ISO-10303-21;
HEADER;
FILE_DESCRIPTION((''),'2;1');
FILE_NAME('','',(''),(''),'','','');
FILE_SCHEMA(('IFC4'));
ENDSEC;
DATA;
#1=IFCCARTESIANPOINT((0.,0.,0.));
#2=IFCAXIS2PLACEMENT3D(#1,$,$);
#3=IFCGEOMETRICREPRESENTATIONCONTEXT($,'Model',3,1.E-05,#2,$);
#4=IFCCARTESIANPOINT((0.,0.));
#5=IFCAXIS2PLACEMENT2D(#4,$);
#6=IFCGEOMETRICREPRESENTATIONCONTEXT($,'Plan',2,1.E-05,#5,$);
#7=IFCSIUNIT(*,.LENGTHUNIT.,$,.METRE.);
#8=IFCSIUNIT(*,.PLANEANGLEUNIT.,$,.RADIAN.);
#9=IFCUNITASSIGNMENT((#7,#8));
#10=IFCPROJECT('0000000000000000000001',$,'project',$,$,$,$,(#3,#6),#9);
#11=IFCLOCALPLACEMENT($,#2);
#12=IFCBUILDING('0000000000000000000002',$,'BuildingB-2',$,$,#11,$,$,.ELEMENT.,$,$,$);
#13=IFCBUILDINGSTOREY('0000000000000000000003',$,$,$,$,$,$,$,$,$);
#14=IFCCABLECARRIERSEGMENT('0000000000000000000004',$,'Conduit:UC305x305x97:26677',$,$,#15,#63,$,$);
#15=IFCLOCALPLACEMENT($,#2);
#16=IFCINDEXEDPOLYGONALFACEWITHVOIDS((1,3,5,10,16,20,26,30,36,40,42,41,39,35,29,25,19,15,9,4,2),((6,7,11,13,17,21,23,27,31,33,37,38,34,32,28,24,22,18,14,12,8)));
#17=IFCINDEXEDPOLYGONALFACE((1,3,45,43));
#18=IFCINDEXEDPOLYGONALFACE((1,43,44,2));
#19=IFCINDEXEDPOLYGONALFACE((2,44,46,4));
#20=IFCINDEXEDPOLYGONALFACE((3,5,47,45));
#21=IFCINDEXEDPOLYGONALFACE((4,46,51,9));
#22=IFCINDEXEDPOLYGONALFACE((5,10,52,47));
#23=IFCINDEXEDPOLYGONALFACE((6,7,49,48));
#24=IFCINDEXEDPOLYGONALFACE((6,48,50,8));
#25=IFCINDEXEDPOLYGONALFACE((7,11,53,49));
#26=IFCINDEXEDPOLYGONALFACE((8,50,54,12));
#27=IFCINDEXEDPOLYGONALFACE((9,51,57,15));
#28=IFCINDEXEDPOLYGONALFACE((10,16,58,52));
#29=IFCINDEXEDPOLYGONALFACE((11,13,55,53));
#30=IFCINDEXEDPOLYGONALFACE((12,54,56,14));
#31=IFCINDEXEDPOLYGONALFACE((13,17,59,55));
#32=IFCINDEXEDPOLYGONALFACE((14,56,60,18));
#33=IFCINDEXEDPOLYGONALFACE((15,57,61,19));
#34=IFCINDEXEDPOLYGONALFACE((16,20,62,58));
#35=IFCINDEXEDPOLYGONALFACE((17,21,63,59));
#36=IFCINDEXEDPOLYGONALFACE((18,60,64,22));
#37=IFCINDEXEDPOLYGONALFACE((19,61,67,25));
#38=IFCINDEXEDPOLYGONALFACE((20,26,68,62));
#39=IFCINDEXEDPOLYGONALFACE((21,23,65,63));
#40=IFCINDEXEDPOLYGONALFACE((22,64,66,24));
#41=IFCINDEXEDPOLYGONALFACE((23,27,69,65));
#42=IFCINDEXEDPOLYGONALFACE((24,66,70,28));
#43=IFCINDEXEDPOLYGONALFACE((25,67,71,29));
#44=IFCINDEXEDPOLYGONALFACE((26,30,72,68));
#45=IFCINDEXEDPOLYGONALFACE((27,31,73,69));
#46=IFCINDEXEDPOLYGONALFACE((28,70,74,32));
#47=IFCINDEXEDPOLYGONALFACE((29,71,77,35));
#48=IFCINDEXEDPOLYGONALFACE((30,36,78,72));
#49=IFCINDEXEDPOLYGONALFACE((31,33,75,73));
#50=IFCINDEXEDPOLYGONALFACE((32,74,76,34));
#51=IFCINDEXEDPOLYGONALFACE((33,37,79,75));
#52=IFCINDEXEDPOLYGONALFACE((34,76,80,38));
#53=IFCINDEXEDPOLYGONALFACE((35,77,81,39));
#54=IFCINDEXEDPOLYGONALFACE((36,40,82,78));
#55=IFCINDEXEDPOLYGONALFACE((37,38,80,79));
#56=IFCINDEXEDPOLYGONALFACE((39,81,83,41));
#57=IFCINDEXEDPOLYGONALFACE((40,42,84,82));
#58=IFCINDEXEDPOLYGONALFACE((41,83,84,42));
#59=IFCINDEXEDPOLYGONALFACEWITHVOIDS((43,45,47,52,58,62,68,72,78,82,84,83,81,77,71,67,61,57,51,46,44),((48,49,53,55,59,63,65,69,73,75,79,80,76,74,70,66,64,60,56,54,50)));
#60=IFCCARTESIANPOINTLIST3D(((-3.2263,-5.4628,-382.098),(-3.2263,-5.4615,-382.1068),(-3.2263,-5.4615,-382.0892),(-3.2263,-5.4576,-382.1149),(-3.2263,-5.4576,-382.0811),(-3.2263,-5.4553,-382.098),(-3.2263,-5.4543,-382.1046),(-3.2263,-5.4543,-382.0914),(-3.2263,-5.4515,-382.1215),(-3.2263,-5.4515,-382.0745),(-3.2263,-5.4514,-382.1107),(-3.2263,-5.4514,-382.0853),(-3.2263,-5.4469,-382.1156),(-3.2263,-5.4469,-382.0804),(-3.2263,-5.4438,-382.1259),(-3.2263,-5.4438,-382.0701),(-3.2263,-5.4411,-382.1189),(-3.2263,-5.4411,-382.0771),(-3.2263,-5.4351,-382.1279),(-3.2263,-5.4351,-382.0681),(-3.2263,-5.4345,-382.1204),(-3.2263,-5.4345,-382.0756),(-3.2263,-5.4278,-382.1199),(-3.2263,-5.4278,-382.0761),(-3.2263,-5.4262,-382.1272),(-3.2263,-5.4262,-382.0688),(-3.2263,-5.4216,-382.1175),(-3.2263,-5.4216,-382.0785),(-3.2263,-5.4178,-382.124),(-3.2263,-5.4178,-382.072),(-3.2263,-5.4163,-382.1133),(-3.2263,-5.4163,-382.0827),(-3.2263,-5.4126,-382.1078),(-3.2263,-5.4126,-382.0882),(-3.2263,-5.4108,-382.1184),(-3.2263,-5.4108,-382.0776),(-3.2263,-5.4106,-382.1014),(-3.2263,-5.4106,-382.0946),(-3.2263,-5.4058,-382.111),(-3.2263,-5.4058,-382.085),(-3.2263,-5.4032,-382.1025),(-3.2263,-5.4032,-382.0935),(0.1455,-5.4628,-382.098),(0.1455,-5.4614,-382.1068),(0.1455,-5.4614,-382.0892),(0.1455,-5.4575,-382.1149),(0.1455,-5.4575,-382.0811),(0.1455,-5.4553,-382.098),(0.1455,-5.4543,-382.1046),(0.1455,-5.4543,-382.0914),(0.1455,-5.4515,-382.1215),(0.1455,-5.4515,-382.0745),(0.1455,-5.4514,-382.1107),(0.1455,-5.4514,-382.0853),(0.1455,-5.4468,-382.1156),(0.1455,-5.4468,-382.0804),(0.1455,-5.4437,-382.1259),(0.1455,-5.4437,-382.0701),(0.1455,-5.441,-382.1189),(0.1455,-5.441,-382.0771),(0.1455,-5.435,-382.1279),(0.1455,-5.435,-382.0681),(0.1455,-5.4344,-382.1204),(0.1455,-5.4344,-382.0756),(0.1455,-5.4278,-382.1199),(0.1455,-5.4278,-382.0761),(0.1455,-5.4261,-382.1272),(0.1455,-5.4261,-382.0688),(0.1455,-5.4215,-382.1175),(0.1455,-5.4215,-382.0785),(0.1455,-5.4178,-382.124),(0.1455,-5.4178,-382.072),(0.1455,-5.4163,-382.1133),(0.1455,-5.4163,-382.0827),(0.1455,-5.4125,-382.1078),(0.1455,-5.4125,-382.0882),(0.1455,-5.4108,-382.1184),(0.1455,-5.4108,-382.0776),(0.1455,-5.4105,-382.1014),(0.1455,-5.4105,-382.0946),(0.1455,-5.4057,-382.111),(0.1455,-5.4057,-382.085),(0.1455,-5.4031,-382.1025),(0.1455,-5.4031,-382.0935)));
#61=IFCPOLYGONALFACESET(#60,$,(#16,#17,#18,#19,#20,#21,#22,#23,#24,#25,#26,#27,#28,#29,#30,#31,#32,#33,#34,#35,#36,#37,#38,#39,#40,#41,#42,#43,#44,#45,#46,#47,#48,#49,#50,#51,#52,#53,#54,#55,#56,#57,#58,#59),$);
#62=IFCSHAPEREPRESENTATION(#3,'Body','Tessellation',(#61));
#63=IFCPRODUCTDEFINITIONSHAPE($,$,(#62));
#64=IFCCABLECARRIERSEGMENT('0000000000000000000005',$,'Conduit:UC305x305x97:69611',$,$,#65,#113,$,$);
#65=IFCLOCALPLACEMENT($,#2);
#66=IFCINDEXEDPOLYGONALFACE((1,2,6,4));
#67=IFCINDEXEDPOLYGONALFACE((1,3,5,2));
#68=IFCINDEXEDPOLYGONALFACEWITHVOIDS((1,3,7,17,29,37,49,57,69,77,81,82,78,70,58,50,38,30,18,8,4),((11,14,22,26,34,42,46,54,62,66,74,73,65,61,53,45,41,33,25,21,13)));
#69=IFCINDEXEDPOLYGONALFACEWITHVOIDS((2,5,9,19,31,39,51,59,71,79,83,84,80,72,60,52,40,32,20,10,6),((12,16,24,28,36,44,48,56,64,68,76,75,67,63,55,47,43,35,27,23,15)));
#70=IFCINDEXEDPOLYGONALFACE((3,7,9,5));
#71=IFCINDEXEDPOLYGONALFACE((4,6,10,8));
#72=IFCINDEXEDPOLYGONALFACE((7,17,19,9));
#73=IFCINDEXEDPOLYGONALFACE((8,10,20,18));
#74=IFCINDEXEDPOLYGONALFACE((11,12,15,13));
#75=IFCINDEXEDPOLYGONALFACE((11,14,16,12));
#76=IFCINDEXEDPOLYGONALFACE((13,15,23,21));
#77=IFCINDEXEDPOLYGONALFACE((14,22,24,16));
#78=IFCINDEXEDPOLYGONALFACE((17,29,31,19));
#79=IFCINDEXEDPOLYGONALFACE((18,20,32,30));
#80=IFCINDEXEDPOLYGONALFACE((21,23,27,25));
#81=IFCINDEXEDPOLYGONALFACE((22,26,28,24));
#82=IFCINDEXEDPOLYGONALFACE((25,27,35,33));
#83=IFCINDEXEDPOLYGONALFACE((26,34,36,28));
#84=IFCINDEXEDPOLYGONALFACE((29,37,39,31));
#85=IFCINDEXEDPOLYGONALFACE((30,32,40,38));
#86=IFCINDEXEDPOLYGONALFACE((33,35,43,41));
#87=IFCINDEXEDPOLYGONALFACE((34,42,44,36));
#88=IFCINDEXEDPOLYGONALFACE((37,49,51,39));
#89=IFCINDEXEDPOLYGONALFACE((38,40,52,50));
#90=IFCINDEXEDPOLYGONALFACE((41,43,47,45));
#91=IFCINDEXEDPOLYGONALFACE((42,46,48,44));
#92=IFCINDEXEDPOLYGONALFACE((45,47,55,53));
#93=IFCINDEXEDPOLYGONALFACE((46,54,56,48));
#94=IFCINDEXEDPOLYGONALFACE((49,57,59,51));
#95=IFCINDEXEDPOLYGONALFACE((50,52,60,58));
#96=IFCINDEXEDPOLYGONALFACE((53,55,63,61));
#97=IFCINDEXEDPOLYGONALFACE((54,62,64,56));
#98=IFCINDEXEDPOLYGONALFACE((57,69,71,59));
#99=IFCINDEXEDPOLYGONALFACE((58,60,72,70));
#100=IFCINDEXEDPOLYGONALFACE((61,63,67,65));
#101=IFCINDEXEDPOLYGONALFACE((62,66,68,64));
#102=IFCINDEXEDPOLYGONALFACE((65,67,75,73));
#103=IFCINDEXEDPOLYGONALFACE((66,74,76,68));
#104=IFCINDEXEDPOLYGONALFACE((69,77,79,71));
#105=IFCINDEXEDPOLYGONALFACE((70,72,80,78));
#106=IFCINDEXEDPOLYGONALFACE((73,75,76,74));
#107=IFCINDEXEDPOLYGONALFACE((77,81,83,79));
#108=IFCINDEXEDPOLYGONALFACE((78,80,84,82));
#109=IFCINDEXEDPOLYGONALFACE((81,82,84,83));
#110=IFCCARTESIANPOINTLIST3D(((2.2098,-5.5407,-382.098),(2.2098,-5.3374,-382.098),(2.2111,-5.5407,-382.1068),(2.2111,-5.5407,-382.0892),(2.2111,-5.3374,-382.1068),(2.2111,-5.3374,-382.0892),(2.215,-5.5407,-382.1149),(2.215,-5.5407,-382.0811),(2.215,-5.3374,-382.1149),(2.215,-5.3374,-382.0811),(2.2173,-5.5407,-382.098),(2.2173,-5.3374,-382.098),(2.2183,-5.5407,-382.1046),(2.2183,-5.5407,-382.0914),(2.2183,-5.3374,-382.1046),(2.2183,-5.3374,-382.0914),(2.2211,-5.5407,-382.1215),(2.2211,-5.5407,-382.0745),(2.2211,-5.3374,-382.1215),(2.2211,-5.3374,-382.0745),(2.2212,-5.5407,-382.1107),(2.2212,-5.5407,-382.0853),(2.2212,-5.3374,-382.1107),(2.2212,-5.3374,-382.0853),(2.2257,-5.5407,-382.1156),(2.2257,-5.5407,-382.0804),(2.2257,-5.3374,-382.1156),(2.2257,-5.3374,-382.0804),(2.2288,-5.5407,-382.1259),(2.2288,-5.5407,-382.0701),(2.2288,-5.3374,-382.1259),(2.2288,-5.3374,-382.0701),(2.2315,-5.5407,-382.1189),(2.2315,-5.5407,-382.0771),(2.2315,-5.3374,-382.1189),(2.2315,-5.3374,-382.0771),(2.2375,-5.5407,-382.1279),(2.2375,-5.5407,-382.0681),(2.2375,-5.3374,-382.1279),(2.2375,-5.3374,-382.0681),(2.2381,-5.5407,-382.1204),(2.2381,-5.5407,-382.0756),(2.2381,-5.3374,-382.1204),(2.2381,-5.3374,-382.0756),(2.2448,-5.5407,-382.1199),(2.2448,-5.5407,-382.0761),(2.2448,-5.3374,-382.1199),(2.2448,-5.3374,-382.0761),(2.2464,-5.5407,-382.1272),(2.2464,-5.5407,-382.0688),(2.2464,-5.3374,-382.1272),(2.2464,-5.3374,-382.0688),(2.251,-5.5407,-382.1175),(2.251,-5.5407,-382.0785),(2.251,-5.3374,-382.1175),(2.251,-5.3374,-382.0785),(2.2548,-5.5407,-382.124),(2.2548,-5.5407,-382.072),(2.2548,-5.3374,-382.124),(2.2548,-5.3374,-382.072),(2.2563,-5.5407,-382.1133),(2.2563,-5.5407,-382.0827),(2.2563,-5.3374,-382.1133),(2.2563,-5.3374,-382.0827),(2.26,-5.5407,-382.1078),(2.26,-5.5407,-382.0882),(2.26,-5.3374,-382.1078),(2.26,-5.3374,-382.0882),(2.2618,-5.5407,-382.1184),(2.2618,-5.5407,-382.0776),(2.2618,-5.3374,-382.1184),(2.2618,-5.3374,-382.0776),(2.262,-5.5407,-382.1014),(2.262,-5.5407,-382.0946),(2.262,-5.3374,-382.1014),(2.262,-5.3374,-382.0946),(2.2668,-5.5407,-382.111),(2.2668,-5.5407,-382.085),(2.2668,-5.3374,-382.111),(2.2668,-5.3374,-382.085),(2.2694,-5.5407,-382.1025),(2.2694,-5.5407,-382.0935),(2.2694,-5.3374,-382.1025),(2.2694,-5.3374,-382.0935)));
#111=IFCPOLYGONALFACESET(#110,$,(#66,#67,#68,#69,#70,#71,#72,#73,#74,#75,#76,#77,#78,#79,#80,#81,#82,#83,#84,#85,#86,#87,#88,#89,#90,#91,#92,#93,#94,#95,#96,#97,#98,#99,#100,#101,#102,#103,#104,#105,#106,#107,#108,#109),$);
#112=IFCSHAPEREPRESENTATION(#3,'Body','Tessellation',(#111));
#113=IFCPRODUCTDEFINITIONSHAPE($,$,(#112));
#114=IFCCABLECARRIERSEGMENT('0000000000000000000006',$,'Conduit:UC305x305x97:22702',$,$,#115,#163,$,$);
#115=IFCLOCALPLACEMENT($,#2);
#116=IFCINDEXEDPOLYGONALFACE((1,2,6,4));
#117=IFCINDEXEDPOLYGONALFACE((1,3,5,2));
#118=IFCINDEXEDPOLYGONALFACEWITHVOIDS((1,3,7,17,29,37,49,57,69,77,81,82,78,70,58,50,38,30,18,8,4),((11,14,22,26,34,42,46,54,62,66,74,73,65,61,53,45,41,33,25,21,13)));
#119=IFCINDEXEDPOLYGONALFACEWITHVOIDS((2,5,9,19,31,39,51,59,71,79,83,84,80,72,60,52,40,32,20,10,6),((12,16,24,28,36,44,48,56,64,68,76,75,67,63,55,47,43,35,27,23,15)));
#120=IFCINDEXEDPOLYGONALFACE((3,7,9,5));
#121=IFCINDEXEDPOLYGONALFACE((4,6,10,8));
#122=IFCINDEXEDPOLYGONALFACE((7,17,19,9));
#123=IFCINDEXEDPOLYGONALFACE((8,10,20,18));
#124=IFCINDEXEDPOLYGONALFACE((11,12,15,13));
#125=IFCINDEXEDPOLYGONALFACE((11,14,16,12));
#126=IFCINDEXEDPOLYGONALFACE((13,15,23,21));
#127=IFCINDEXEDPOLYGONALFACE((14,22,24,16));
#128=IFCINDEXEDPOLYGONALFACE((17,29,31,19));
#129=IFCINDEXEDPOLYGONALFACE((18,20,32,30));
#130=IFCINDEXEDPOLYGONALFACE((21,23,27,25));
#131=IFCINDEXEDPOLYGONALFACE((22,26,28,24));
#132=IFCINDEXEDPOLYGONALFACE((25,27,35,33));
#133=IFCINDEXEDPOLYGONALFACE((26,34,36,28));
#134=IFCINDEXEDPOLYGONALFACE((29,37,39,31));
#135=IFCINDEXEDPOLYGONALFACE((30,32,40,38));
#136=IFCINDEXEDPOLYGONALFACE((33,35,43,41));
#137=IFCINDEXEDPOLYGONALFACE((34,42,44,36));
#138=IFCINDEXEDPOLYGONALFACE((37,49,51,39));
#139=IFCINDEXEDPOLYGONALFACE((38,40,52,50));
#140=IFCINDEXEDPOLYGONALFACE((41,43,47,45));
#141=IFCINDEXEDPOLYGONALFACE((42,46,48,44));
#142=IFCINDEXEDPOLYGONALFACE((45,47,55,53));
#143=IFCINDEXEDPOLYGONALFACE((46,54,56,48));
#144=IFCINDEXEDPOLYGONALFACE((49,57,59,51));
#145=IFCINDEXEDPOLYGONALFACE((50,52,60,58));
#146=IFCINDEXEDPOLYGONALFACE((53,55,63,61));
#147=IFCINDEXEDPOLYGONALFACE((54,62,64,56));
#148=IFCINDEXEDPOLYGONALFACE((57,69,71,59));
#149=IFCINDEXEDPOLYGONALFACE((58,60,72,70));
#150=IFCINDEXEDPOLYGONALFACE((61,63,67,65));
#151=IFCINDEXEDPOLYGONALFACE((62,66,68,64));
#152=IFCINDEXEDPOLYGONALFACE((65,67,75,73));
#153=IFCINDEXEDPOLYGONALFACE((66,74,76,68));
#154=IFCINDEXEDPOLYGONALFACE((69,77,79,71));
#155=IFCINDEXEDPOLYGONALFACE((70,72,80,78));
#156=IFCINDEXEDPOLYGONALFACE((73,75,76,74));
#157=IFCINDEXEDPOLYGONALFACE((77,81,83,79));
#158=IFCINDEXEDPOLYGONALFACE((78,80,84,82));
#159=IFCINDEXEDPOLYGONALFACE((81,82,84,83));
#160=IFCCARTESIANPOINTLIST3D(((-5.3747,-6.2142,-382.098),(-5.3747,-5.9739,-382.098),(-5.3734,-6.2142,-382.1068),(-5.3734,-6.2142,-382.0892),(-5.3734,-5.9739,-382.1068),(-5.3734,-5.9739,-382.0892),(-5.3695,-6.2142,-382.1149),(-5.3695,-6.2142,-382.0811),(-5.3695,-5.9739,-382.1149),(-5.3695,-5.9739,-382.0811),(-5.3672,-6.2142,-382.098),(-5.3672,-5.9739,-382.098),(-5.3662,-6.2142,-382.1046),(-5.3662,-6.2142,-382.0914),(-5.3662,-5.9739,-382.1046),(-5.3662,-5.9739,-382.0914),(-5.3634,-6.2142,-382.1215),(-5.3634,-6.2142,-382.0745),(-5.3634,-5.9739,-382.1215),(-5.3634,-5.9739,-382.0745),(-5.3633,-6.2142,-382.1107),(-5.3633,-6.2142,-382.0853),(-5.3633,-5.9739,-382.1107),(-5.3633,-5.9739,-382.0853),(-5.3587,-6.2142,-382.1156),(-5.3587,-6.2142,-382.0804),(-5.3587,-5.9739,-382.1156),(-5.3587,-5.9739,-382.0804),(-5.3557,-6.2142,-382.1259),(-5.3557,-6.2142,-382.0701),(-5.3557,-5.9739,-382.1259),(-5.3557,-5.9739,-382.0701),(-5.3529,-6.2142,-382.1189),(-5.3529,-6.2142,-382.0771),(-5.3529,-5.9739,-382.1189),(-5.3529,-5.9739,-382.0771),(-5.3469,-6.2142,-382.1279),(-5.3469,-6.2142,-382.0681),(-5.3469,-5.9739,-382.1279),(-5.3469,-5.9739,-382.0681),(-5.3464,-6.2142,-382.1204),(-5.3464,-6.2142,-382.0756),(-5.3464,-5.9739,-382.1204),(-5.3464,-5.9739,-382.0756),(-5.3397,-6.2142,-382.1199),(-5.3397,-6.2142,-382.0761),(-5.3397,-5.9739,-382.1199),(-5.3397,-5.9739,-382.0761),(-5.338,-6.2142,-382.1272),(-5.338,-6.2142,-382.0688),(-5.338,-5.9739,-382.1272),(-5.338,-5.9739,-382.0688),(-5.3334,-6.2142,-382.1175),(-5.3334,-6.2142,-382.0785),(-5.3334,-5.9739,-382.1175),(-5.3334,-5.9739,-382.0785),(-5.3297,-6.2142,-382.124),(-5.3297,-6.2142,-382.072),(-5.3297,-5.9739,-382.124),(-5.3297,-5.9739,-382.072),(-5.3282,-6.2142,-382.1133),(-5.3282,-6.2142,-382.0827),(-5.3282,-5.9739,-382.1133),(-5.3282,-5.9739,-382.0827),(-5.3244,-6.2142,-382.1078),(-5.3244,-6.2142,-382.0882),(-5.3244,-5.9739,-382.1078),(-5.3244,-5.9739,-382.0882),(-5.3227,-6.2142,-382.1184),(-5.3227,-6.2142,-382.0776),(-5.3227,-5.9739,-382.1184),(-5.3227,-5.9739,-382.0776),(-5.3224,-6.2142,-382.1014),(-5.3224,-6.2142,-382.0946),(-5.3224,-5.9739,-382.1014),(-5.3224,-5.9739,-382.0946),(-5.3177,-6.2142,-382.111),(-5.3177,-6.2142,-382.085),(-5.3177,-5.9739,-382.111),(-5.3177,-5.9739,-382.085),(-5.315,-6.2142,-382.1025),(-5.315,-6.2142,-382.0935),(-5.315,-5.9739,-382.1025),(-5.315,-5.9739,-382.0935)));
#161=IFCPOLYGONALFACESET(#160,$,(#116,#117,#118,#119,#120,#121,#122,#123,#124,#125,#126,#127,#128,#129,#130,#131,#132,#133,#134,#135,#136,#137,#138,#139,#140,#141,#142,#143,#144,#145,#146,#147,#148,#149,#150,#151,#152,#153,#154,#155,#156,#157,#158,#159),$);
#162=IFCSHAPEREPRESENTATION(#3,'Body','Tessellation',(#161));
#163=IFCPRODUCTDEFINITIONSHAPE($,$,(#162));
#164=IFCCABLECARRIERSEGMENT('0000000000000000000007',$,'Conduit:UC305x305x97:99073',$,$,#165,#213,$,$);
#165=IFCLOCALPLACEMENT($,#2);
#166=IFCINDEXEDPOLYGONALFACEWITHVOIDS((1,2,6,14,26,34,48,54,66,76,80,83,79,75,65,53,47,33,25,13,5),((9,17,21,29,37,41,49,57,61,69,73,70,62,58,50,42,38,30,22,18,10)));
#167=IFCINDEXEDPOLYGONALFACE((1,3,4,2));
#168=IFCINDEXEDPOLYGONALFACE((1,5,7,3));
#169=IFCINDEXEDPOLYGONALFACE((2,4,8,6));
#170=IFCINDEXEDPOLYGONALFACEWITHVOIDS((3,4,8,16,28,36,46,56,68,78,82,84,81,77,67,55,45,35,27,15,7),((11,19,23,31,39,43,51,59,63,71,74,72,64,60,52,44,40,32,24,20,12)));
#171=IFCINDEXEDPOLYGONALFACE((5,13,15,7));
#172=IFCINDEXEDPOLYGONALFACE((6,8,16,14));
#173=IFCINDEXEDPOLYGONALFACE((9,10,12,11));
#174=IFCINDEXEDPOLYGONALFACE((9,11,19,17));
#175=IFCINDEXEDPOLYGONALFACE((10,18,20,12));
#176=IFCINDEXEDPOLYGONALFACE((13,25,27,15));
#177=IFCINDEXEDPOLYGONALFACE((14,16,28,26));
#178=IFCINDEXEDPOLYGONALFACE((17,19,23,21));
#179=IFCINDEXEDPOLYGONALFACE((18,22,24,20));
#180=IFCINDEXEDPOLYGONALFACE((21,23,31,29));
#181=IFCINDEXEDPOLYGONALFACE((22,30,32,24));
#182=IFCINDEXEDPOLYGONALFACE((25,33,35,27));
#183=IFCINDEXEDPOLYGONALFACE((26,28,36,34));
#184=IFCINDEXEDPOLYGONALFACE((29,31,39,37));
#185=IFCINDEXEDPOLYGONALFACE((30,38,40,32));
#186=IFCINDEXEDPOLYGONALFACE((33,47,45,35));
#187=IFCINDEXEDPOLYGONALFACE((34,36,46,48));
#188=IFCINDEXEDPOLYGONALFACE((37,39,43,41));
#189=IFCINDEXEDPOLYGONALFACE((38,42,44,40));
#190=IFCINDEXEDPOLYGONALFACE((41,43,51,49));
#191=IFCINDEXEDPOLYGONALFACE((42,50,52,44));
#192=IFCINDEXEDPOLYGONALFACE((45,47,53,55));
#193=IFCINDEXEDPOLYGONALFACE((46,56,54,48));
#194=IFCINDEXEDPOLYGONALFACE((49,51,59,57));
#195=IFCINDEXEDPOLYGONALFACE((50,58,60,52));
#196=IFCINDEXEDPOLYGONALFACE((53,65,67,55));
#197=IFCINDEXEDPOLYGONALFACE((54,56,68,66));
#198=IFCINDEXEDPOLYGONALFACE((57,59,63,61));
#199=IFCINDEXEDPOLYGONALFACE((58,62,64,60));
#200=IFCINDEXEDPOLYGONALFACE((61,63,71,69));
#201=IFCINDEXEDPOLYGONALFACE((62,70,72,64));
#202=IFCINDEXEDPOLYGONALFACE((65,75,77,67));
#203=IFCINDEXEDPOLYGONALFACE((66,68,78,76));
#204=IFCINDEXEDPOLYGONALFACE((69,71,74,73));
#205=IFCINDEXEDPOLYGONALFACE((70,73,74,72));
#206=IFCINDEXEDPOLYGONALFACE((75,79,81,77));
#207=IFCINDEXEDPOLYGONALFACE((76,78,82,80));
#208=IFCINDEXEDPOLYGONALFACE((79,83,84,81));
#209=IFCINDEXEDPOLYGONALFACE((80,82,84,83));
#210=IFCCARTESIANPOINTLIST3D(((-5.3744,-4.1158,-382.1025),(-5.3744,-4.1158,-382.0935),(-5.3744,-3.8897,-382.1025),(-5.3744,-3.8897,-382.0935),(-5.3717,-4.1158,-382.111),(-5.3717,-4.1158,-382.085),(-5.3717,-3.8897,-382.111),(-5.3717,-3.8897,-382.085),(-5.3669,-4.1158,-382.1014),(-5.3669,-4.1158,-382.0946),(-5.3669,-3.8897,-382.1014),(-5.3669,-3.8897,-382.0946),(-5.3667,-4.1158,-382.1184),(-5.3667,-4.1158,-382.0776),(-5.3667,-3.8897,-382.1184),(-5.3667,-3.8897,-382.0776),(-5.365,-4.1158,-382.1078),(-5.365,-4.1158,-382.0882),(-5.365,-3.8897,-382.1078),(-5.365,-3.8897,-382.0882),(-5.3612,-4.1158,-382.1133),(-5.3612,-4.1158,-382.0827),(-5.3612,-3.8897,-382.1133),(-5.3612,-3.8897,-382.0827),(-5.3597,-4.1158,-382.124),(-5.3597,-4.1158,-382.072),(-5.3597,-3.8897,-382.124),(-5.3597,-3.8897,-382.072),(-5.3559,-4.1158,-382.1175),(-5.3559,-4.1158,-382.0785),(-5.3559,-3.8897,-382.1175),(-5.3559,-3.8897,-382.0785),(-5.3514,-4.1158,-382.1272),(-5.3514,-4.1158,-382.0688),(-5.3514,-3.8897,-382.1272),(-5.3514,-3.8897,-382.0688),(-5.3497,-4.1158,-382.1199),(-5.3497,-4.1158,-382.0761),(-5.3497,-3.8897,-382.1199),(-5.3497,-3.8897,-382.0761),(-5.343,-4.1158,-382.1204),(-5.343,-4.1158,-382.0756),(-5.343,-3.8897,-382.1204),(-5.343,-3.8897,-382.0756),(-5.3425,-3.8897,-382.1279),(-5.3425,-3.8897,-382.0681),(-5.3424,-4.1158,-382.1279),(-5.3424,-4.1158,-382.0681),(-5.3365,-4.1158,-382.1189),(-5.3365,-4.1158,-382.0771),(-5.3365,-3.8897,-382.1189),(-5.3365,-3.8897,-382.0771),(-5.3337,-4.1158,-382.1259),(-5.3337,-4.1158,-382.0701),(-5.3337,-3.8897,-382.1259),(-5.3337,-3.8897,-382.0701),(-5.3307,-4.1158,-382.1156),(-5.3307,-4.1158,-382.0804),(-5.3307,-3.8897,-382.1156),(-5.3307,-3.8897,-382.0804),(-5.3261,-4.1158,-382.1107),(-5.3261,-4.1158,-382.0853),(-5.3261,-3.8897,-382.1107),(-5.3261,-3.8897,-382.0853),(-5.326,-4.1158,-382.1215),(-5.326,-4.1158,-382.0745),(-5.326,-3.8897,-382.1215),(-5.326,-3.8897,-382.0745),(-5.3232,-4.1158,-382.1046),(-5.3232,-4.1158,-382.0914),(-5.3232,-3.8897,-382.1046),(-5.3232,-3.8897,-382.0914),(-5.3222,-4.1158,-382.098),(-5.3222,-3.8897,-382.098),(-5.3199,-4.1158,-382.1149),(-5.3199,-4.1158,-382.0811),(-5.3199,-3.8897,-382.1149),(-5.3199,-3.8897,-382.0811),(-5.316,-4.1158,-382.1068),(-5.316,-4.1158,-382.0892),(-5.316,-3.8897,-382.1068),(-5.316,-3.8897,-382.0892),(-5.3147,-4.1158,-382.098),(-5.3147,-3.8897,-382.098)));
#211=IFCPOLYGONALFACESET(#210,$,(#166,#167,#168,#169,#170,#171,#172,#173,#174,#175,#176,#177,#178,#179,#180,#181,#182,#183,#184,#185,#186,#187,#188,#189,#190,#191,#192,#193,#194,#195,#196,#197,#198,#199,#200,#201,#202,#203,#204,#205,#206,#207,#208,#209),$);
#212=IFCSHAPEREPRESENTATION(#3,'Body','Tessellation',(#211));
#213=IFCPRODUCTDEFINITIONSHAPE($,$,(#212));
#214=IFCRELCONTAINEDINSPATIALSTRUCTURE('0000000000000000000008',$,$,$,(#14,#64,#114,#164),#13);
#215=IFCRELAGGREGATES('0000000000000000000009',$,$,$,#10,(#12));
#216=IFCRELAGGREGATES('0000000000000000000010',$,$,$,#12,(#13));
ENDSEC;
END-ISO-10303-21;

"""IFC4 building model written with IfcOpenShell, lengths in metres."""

from ifc_helpers import new_model, entity, si_unit, origin, origin_2d, place, context, project, spatial, element, save


model = new_model("IFC4")

# Units and contexts
model_context = context("Model", 3, precision=1e-05, world=origin())
plan_context = context("Plan", 2, precision=1e-05, world=origin_2d())
ifc_project = project(units=[si_unit("LENGTHUNIT", "METRE"), si_unit("PLANEANGLEUNIT", "RADIAN")], contexts=[model_context, plan_context])

# Building, storey
building_placement = place(None, origin())
building = spatial("IfcBuilding", under=ifc_project, at=building_placement, Name="BuildingB-2", CompositionType="ELEMENT")
storey = spatial("IfcBuildingStorey", under=building)

# Cable carrier segments
element("IfcCableCarrierSegment", 1, inside=storey, Name="Conduit:UC305x305x97:26677", context=model_context, shape_type="AdvancedSweptSolid", body=[
    entity("IfcSweptDiskSolid", entity("IfcCompositeCurve", [entity("IfcCompositeCurveSegment", "CONTINUOUS", False, entity("IfcPolyline", [entity("IfcCartesianPoint", [3.2263, 5.4328, 382.098]), entity("IfcCartesianPoint", [-0.1455, 5.4328, 382.098])]))], False), 0.03, 0.0225),
])
element("IfcCableCarrierSegment", 2, inside=storey, Name="Conduit:UC305x305x97:69611", context=model_context, shape_type="AdvancedSweptSolid", body=[
    entity("IfcSweptDiskSolid", entity("IfcCompositeCurve", [entity("IfcCompositeCurveSegment", "CONTINUOUS", False, entity("IfcPolyline", [entity("IfcCartesianPoint", [-2.2398, 5.5407, 382.098]), entity("IfcCartesianPoint", [-2.2398, 5.3374, 382.098])]))], False), 0.03, 0.0225),
])
element("IfcCableCarrierSegment", 3, inside=storey, Name="Conduit:UC305x305x97:22702", context=model_context, shape_type="AdvancedSweptSolid", body=[
    entity("IfcSweptDiskSolid", entity("IfcCompositeCurve", [entity("IfcCompositeCurveSegment", "CONTINUOUS", False, entity("IfcPolyline", [entity("IfcCartesianPoint", [5.3447, 6.2142, 382.098]), entity("IfcCartesianPoint", [5.3447, 5.9739, 382.098])]))], False), 0.03, 0.0225),
])
element("IfcCableCarrierSegment", 4, inside=storey, Name="Conduit:UC305x305x97:99073", context=model_context, shape_type="AdvancedSweptSolid", body=[
    entity("IfcSweptDiskSolid", entity("IfcCompositeCurve", [entity("IfcCompositeCurveSegment", "CONTINUOUS", False, entity("IfcPolyline", [entity("IfcCartesianPoint", [5.3447, 3.8897, 382.098]), entity("IfcCartesianPoint", [5.3447, 4.1158, 382.098])]))], False), 0.03, 0.0225),
])

save(model, "model.ifc")
